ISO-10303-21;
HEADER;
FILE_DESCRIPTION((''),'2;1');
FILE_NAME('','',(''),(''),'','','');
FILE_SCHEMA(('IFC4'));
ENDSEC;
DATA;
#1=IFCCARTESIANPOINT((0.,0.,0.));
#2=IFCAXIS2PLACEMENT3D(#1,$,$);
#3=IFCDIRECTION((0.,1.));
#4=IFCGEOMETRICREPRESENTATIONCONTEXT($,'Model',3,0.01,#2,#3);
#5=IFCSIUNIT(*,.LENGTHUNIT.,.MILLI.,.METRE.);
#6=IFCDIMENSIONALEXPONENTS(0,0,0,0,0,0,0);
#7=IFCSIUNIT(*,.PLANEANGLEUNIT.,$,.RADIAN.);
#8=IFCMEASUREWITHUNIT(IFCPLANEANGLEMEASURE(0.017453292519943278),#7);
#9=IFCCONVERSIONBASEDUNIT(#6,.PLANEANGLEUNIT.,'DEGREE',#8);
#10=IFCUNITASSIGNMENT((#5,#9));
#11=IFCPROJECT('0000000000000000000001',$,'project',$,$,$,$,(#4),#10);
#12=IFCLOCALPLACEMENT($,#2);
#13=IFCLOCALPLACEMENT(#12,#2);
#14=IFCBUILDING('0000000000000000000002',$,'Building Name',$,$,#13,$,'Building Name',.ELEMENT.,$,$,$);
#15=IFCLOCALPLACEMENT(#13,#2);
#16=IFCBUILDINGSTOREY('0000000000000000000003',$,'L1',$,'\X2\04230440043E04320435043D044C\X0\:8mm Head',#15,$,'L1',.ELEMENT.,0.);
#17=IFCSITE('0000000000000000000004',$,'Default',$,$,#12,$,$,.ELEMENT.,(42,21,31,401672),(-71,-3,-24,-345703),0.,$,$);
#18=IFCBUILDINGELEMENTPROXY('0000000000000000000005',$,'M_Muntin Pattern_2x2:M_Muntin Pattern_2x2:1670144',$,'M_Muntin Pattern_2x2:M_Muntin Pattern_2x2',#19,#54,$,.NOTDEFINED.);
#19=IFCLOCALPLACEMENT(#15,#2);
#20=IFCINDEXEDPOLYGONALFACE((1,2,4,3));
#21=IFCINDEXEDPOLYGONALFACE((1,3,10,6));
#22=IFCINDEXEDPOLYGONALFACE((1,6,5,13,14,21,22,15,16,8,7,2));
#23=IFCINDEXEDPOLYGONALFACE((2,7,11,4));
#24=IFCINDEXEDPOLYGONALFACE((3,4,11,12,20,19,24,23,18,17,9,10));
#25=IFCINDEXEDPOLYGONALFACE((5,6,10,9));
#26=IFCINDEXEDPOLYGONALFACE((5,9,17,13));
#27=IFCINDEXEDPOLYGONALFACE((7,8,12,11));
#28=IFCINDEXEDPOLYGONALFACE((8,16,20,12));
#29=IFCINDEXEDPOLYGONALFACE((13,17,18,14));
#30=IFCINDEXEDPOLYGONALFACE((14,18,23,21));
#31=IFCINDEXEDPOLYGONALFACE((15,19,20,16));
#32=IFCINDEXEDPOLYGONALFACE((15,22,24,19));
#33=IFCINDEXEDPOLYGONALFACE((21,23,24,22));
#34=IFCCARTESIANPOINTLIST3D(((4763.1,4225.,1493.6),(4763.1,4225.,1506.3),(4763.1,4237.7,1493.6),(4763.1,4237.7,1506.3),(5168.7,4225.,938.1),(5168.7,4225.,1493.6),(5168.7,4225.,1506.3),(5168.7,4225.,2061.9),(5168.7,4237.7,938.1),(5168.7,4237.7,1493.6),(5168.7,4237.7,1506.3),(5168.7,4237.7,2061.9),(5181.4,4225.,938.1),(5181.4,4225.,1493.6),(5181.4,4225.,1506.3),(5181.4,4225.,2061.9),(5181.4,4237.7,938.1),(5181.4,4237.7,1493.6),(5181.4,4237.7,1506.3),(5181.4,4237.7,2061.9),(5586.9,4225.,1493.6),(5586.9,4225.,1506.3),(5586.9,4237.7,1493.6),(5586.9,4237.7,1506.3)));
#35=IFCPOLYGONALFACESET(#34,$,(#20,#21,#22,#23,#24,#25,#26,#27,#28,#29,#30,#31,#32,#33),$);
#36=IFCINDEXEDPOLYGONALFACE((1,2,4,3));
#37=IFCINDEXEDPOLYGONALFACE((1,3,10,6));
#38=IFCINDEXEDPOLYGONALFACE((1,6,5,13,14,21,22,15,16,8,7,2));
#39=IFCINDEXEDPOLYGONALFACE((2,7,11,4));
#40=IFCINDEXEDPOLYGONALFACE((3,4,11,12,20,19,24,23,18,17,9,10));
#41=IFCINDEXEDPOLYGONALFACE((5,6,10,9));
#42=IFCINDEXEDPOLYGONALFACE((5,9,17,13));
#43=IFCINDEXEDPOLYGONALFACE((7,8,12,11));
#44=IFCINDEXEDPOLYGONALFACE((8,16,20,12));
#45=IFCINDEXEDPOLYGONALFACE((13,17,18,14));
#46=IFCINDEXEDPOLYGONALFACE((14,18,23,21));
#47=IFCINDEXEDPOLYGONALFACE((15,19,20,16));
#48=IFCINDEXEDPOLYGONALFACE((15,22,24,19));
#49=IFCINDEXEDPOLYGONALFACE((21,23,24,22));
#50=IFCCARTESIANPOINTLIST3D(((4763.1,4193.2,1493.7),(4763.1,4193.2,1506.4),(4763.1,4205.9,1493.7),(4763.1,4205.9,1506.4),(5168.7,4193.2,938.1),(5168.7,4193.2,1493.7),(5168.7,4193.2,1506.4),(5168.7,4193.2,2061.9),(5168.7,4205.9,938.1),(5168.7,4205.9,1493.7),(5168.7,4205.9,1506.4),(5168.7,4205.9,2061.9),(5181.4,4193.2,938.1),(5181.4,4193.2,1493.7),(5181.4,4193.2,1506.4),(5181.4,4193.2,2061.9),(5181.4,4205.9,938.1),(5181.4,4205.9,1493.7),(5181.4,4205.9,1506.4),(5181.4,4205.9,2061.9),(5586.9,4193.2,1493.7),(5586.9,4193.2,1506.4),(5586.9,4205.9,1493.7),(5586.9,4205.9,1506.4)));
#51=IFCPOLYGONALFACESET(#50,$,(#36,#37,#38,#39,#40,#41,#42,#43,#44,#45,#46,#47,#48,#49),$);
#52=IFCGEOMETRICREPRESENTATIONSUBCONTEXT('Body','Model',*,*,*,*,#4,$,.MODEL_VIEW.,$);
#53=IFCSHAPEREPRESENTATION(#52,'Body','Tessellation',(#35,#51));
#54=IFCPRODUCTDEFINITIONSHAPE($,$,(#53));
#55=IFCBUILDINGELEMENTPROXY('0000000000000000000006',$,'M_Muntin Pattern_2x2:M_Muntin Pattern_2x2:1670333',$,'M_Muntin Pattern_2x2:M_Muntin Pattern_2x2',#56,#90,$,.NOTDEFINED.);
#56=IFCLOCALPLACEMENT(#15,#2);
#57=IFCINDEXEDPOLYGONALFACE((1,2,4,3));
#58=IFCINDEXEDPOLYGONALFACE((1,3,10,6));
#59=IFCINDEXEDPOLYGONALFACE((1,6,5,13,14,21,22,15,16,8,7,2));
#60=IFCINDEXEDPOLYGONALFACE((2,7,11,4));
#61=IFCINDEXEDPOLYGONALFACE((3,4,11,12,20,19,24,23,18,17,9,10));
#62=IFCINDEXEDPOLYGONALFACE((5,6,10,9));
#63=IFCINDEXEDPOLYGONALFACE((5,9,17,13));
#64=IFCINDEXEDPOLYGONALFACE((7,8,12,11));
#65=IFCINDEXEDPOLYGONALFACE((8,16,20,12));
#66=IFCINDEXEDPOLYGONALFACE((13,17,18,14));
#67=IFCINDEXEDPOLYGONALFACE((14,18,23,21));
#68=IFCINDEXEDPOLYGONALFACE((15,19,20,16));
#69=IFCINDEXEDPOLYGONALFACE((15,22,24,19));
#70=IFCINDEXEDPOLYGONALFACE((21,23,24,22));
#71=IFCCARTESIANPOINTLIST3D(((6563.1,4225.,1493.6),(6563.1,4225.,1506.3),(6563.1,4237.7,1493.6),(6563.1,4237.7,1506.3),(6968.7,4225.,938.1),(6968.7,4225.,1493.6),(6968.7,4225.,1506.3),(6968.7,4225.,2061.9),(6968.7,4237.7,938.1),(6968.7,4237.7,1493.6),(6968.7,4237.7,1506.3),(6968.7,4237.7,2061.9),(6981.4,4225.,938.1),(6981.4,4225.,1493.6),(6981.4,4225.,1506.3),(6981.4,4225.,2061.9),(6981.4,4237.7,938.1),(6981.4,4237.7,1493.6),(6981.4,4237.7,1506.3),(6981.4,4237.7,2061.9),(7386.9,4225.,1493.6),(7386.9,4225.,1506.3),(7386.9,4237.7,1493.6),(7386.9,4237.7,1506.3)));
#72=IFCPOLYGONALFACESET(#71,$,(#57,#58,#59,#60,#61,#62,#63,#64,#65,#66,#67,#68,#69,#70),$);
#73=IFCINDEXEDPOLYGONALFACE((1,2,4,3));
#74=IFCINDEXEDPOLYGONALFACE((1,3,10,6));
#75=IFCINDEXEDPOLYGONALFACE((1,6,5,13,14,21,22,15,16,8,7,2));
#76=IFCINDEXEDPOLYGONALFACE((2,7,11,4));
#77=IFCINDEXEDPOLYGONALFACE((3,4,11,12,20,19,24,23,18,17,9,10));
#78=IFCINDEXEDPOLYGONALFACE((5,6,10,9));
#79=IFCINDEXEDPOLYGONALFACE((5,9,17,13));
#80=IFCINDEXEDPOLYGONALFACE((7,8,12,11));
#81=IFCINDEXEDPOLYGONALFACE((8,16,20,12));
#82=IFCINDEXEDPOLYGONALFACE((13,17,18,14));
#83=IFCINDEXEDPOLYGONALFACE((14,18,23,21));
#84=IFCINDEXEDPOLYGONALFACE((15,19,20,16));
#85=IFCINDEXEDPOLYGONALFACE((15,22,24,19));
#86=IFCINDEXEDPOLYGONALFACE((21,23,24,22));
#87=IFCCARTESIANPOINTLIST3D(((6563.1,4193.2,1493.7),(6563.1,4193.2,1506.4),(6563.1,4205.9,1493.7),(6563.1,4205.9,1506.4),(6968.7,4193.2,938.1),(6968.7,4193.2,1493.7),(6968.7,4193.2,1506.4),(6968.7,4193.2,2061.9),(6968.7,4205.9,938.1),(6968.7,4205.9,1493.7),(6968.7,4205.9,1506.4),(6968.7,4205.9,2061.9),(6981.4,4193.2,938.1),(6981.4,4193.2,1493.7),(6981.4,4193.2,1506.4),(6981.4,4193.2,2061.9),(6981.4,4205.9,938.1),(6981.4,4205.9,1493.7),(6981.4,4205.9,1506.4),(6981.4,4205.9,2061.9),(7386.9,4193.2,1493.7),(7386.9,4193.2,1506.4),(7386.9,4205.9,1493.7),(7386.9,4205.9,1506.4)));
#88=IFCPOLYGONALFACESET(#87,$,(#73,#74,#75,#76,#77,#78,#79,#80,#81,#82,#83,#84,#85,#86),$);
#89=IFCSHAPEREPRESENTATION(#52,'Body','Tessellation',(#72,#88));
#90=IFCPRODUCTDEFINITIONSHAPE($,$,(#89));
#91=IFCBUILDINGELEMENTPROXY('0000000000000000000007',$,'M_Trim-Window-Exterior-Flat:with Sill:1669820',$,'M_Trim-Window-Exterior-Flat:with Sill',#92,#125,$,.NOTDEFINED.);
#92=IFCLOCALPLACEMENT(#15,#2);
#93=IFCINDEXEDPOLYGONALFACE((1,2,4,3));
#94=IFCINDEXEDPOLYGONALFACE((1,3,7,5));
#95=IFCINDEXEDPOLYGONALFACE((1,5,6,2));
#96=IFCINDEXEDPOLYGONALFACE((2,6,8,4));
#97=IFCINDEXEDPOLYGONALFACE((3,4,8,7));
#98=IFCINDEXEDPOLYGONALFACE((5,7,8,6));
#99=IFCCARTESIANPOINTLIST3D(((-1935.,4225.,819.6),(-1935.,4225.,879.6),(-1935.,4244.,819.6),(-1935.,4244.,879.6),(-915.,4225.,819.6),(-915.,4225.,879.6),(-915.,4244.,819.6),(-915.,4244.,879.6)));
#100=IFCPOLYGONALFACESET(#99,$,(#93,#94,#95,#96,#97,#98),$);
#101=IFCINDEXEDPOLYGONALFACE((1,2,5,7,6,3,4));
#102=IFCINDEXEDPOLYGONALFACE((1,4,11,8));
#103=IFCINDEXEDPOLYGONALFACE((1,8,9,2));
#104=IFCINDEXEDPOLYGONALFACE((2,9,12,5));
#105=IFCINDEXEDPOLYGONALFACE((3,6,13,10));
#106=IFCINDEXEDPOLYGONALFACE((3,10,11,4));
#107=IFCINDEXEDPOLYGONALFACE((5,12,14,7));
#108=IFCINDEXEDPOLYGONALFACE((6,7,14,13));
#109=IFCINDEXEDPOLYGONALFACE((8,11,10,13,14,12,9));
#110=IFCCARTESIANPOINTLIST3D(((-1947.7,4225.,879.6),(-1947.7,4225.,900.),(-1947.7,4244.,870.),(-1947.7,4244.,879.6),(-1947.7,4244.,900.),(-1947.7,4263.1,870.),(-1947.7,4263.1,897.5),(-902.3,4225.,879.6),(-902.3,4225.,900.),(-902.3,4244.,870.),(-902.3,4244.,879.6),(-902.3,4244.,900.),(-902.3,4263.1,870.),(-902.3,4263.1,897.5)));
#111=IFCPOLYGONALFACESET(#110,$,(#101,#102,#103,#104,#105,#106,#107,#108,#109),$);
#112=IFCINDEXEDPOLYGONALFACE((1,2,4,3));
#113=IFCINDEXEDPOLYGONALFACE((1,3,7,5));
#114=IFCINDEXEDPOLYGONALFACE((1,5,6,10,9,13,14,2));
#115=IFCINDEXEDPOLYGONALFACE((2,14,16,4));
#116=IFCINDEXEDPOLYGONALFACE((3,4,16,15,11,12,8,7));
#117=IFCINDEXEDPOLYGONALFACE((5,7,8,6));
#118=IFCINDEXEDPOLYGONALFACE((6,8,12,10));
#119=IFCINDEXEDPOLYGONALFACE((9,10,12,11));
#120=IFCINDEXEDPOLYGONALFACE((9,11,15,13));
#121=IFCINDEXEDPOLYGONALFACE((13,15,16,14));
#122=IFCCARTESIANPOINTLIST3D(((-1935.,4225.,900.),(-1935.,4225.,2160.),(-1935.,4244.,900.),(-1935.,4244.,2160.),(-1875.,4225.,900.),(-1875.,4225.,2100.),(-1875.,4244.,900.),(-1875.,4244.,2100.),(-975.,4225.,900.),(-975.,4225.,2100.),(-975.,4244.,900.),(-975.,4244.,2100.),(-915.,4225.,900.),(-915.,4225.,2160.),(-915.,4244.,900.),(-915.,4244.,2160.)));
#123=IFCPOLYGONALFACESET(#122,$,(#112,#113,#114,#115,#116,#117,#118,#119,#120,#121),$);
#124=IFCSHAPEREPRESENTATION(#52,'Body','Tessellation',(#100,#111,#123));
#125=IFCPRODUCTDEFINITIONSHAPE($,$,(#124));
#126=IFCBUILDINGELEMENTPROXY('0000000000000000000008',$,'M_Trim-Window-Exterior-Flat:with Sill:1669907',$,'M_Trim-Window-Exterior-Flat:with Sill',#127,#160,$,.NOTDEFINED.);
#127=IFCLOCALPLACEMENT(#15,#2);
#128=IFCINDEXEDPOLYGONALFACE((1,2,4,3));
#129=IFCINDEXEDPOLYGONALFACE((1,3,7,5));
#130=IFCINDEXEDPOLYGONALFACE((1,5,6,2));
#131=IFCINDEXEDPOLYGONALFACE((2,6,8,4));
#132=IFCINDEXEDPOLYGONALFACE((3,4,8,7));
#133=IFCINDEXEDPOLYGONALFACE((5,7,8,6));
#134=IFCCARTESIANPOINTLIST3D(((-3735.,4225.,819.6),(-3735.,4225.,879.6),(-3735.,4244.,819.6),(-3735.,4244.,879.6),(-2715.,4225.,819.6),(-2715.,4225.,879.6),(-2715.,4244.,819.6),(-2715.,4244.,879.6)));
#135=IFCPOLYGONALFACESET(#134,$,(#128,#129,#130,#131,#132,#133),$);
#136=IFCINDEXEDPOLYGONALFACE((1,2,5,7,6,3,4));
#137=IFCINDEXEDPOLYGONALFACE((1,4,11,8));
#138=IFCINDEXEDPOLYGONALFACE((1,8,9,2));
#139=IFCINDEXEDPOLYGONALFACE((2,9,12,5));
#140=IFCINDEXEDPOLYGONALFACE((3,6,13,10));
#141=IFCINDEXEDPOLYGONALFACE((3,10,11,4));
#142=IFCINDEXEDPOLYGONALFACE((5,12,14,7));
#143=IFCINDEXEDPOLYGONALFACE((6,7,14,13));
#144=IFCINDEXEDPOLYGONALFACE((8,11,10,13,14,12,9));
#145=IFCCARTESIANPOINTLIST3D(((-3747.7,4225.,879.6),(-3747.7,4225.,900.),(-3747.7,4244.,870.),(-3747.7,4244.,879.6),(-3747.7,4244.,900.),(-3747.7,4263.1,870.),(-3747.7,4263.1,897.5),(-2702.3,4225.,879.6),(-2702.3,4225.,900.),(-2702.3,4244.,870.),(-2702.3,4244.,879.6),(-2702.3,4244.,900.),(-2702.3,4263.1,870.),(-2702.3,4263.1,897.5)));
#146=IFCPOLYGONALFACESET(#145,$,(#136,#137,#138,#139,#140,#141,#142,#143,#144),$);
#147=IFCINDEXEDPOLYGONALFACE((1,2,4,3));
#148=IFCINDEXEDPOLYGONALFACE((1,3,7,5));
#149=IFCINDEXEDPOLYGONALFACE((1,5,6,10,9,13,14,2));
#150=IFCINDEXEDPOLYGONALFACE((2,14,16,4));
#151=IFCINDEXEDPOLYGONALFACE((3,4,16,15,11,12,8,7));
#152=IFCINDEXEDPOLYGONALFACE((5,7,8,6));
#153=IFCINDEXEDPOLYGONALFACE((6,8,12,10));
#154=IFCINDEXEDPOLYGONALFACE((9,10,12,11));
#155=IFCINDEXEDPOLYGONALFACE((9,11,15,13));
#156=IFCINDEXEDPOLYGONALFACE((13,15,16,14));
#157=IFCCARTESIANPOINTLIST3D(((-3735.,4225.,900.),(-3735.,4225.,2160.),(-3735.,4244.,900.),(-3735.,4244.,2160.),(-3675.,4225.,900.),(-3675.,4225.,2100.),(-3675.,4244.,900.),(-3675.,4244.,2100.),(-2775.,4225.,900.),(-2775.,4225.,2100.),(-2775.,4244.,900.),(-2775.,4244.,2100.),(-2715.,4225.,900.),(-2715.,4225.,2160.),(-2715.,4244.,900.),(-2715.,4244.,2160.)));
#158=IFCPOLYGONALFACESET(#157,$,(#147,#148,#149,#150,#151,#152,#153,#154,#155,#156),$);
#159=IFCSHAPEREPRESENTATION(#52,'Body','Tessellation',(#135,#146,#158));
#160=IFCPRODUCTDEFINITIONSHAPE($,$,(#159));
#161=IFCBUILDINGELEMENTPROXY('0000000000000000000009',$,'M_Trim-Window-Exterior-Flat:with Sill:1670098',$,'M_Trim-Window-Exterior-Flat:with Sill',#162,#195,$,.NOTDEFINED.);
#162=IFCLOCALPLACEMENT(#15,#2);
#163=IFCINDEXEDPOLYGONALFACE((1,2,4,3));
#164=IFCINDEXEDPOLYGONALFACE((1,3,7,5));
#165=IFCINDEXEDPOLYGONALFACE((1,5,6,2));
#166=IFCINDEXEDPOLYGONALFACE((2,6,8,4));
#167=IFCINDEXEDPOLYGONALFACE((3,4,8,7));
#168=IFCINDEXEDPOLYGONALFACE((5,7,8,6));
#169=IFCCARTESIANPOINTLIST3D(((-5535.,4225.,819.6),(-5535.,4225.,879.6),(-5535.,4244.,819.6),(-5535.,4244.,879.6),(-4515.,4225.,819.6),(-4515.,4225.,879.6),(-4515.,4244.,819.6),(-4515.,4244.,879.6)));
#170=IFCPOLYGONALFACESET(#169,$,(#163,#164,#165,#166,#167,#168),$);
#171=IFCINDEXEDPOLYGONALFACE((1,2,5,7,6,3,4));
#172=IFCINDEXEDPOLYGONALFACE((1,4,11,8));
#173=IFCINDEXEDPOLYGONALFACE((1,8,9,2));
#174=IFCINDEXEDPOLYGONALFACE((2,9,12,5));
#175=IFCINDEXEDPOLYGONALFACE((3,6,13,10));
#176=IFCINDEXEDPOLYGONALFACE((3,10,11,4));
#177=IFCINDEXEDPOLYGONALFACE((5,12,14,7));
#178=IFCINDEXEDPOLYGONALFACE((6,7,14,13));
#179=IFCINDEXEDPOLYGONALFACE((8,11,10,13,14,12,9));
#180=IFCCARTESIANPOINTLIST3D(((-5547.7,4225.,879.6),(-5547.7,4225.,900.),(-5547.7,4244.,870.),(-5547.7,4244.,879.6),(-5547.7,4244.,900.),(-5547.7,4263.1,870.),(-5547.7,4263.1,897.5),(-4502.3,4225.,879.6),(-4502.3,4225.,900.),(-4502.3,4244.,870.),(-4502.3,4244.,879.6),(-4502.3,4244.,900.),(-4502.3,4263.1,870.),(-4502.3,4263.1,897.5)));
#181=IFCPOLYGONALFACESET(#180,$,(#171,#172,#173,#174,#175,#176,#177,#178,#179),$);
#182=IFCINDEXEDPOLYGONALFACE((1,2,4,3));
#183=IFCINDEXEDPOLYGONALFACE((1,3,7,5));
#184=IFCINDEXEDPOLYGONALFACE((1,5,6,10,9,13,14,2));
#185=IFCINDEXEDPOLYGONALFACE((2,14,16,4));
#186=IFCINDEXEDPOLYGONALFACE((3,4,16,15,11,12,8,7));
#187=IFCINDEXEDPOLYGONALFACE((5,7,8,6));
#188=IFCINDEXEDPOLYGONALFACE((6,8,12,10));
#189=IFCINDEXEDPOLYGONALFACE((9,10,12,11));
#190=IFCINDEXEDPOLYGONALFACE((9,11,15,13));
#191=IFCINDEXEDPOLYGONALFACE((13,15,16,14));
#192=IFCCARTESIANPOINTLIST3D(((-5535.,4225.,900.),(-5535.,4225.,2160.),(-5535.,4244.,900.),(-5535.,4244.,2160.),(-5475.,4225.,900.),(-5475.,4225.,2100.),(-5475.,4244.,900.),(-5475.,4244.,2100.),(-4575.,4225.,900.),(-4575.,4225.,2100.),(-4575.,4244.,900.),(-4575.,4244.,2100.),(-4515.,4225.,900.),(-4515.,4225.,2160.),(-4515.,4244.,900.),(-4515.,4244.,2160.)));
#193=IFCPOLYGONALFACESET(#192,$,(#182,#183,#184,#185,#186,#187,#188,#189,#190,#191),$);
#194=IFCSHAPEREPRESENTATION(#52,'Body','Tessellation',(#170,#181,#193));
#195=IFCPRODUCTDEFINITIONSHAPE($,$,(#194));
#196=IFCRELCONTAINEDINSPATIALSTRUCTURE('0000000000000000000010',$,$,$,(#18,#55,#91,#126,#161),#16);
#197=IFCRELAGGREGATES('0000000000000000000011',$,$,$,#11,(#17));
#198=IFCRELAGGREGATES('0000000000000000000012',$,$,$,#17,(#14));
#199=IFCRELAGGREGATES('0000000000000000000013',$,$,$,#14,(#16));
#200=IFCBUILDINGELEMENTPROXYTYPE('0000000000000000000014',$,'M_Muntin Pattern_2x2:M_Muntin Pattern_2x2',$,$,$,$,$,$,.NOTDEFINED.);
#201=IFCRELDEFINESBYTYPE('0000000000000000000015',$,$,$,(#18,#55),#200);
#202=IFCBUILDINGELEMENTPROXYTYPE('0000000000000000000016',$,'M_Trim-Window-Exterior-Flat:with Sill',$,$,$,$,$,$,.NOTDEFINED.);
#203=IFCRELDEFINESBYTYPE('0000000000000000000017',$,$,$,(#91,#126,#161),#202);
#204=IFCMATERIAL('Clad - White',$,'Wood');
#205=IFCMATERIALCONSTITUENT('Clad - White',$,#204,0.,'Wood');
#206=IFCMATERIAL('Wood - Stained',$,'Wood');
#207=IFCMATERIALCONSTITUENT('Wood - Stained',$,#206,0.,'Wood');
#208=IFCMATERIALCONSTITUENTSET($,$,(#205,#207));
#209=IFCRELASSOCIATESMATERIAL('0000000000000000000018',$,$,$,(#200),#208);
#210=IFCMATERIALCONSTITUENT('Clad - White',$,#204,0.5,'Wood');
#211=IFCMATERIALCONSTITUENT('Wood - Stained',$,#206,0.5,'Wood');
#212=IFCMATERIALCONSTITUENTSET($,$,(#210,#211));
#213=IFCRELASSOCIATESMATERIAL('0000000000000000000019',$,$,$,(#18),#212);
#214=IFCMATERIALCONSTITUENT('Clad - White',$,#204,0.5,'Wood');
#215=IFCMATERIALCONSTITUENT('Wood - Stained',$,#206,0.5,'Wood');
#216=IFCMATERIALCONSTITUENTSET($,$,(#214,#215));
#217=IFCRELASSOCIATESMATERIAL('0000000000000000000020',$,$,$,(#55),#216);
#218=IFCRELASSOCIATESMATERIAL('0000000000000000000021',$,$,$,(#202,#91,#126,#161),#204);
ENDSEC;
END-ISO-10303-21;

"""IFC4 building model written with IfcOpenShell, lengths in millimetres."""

from ifc_helpers import new_model, entity, si_unit, converted_unit, direction, frame, frame_2d, origin, place, context, subcontext, project, spatial, polyline, rectangle, outline, extrude, source, transform, mapped, material, constituent, constituent_set, type_object, type_shapes, element, save


model = new_model("IFC4")

# Units and contexts
model_context = context("Model", 3, precision=0.01, world=origin(), true_north=direction((0.0, 1.0)))
body_context = subcontext(model_context, "Body", "Model", "MODEL_VIEW")
ifc_project = project(units=[si_unit("LENGTHUNIT", "METRE", prefix="MILLI"), converted_unit("PLANEANGLEUNIT", "DEGREE", entity("IfcPlaneAngleMeasure", 0.017453292519943278), si_unit("PLANEANGLEUNIT", "RADIAN"), dimensions=[0, 0, 0, 0, 0, 0, 0])], contexts=[model_context])

# Site, building, storey
site_placement = place(None, origin())
site = spatial("IfcSite", under=ifc_project, at=site_placement, Name="Default", CompositionType="ELEMENT", RefLatitude=(42, 21, 31, 401672), RefLongitude=(-71, -3, -24, -345703), RefElevation=0.0)
building_placement = place(site_placement, origin())
building = spatial("IfcBuilding", under=site, at=building_placement, Name="Building Name", LongName="Building Name", CompositionType="ELEMENT")
storey_placement = place(building_placement, origin())
storey = spatial("IfcBuildingStorey", under=building, at=storey_placement, Name="L1", ObjectType="Уровень:8mm Head", LongName="L1", CompositionType="ELEMENT", Elevation=0.0)

# Building element proxies
ifc_material_1 = material(Name="Clad - White", Category="Wood")
ifc_material_2 = material(Name="Wood - Stained", Category="Wood")
ifc_constituent_1 = constituent(ifc_material_1, Name="Clad - White", Category="Wood", fraction=0.0)
ifc_constituent_2 = constituent(ifc_material_2, Name="Wood - Stained", Category="Wood", fraction=0.0)
ifc_constituent_set_1 = constituent_set(constituents=[ifc_constituent_1, ifc_constituent_2])
building_element_proxy_type_1 = type_object("IfcBuildingElementProxyType", Name="M_Muntin Pattern_2x2:M_Muntin Pattern_2x2", PredefinedType="NOTDEFINED", material=ifc_constituent_set_1)
shared_shape_1 = source(origin(), body_context, "Body", "SweptSolid", [
    extrude(outline(polyline([(6.4, -6.4), (561.9, -6.4), (561.9, 6.3), (6.4, 6.3), (6.4, 411.9), (-6.3, 411.9), (-6.3, 6.3), (-561.9, 6.3), (-561.9, -6.4), (-6.3, -6.4), (-6.3, -411.9), (6.4, -411.9), (6.4, -6.4)])), frame((0.0, -22.2, 561.9), z_axis=(0.0, 1.0, 0.0), x_axis=(0.0, 0.0, 1.0)), (0.0, 0.0, 1.0), 12.7),
    extrude(outline(polyline([(6.4, -6.4), (561.9, -6.4), (561.9, 6.3), (6.4, 6.3), (6.4, 411.9), (-6.3, 411.9), (-6.3, 6.3), (-561.9, 6.3), (-561.9, -6.4), (-6.3, -6.4), (-6.3, -411.9), (6.4, -411.9), (6.4, -6.4)])), frame((0.0, 9.5, 561.9), z_axis=(0.0, 1.0, 0.0), x_axis=(0.0, 0.0, 1.0)), (0.0, 0.0, 1.0), 12.7),
])
type_shapes(building_element_proxy_type_1, [shared_shape_1])
ifc_constituent_3 = constituent(ifc_material_1, Name="Clad - White", Category="Wood", fraction=0.5)
ifc_constituent_4 = constituent(ifc_material_2, Name="Wood - Stained", Category="Wood", fraction=0.5)
ifc_constituent_set_2 = constituent_set(constituents=[ifc_constituent_3, ifc_constituent_4])
proxy_1_placement = place(storey_placement, frame((5175.0, 4215.5, 938.1), z_axis=(0.0, 0.0, 1.0), x_axis=(-1.0, 0.0, 0.0)))
element("IfcBuildingElementProxy", 1, at=proxy_1_placement, inside=storey, type_object=building_element_proxy_type_1, material=ifc_constituent_set_2, Name="M_Muntin Pattern_2x2:M_Muntin Pattern_2x2:1670144", ObjectType="M_Muntin Pattern_2x2:M_Muntin Pattern_2x2", PredefinedType="NOTDEFINED", context=body_context, shape_type="MappedRepresentation", body=[
    mapped(shared_shape_1, transform((0.0, 0.0, 0.0), scale=1.0)),
])
ifc_constituent_5 = constituent(ifc_material_1, Name="Clad - White", Category="Wood", fraction=0.5)
ifc_constituent_6 = constituent(ifc_material_2, Name="Wood - Stained", Category="Wood", fraction=0.5)
ifc_constituent_set_3 = constituent_set(constituents=[ifc_constituent_5, ifc_constituent_6])
proxy_2_placement = place(storey_placement, frame((6975.0, 4215.5, 938.1), z_axis=(0.0, 0.0, 1.0), x_axis=(-1.0, 0.0, 0.0)))
element("IfcBuildingElementProxy", 2, at=proxy_2_placement, inside=storey, type_object=building_element_proxy_type_1, material=ifc_constituent_set_3, Name="M_Muntin Pattern_2x2:M_Muntin Pattern_2x2:1670333", ObjectType="M_Muntin Pattern_2x2:M_Muntin Pattern_2x2", PredefinedType="NOTDEFINED", context=body_context, shape_type="MappedRepresentation", body=[
    mapped(shared_shape_1, transform((0.0, 0.0, 0.0), scale=1.0)),
])
building_element_proxy_type_2 = type_object("IfcBuildingElementProxyType", Name="M_Trim-Window-Exterior-Flat:with Sill", PredefinedType="NOTDEFINED", material=ifc_material_1)
shared_shape_2 = source(origin(), body_context, "Body", "SweptSolid", [
    extrude(rectangle(XDim=1020.0, YDim=60.0, at=frame_2d((0.0, 0.0), x_axis=(1.0, 0.0))), frame((0.0, -1250.4, 0.0), z_axis=(0.0, 0.0, 1.0), x_axis=(-1.0, 0.0, 0.0)), (0.0, 0.0, 1.0), 19.0),
    extrude(outline(polyline([(-19.0, -15.2), (0.0, -15.2), (0.0, -5.7), (19.0, -5.7), (19.0, 14.8), (0.0, 14.8), (-19.0, 12.3), (-19.0, -15.2)])), frame((-522.7, -1214.8, 19.0), z_axis=(1.0, 0.0, 0.0), x_axis=(0.0, 0.0, -1.0)), (0.0, 0.0, 1.0), 1045.4),
    extrude(outline(polyline([(-645.0, -510.0), (615.0, -510.0), (615.0, -450.0), (-585.0, -450.0), (-585.0, 450.0), (615.0, 450.0), (615.0, 510.0), (-645.0, 510.0), (-645.0, -510.0)])), frame((0.0, -585.0, 0.0), z_axis=(0.0, 0.0, 1.0), x_axis=(0.0, -1.0, 0.0)), (0.0, 0.0, 1.0), 19.0),
])
type_shapes(building_element_proxy_type_2, [shared_shape_2])
for number, where, z_axis, x_axis, name in (
    (3, (-1425.0, 4225.0, 2100.0), (0.0, 1.0, 0.0), (-1.0, 0.0, 0.0), "M_Trim-Window-Exterior-Flat:with Sill:1669820"),
    (4, (-3225.0, 4225.0, 2100.0), (0.0, 1.0, 0.0), (-1.0, 0.0, 0.0), "M_Trim-Window-Exterior-Flat:with Sill:1669907"),
    (5, (-5025.0, 4225.0, 2100.0), (0.0, 1.0, 0.0), (-1.0, 0.0, 0.0), "M_Trim-Window-Exterior-Flat:with Sill:1670098"),
):
    element("IfcBuildingElementProxy", number, at=place(storey_placement, frame(where, z_axis=z_axis, x_axis=x_axis)), inside=storey, type_object=building_element_proxy_type_2, material=ifc_material_1, Name=name, ObjectType="M_Trim-Window-Exterior-Flat:with Sill", PredefinedType="NOTDEFINED", context=body_context, shape_type="MappedRepresentation", body=[
        mapped(shared_shape_2, transform((0.0, 0.0, 0.0), scale=1.0)),
    ])

save(model, "model.ifc")
